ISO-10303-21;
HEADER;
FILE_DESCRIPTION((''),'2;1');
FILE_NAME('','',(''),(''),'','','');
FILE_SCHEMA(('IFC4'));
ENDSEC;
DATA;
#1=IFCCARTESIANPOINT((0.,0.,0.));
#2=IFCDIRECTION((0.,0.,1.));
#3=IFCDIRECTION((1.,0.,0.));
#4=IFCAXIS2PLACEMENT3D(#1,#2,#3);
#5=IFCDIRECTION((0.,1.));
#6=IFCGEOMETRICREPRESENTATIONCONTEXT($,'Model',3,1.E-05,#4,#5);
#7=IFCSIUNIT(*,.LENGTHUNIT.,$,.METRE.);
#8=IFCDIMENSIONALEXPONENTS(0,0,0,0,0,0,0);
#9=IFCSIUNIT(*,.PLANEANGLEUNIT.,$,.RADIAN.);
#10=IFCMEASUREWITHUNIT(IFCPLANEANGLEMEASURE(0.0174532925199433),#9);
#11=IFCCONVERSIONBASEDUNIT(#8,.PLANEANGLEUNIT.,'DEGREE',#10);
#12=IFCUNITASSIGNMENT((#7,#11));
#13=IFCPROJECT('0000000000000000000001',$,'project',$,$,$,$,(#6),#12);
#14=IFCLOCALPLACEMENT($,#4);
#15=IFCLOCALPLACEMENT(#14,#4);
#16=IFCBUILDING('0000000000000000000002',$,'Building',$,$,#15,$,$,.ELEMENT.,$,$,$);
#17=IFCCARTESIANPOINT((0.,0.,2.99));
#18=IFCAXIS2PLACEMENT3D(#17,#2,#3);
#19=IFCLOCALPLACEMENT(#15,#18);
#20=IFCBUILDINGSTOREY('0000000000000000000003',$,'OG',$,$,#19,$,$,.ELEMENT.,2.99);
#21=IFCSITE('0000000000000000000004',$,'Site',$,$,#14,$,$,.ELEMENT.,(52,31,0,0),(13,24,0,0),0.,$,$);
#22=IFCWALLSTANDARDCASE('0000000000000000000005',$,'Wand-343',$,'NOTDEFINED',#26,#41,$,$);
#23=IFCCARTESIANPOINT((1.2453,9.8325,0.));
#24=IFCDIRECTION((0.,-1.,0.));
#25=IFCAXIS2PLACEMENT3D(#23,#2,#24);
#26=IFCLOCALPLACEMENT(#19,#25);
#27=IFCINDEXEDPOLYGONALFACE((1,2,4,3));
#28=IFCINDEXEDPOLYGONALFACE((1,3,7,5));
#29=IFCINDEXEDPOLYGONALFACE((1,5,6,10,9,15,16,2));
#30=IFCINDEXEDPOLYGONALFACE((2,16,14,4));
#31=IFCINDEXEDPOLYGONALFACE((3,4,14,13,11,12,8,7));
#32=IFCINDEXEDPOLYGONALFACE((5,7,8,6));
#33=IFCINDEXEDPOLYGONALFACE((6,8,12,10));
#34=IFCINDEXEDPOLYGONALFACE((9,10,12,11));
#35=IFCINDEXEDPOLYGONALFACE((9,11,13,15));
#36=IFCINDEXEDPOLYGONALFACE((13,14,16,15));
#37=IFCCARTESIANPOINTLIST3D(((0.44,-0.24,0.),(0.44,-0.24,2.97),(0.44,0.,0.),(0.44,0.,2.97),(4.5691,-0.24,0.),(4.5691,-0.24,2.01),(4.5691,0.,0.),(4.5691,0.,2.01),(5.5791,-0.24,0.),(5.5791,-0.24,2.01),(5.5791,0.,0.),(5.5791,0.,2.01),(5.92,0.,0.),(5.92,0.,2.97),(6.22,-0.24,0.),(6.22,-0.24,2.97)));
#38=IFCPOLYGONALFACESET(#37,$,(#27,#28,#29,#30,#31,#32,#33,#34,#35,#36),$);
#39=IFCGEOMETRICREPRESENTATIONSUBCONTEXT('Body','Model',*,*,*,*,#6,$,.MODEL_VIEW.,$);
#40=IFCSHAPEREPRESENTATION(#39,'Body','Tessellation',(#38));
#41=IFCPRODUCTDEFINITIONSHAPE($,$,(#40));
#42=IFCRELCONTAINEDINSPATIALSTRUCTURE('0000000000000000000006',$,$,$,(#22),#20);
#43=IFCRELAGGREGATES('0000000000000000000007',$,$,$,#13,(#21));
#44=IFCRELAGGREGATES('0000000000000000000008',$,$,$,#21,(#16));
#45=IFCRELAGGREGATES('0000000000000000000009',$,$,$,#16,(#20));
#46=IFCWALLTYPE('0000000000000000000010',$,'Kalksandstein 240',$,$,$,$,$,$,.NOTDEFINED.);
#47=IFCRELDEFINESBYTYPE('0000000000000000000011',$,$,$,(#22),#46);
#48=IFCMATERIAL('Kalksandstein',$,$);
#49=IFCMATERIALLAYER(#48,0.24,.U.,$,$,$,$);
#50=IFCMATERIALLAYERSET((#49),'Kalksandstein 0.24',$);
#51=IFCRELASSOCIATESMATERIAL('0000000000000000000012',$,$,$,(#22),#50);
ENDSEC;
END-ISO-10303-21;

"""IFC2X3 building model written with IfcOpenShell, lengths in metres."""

from ifc_helpers import new_model, entity, si_unit, converted_unit, direction, frame, origin_with_axes, origin_2d_with_axis, place, context, subcontext, project, spatial, polyline, rectangle, outline, extrude, material, layer, layer_set, layer_usage, type_object, element, save


model = new_model("IFC2X3")

# Units and contexts
model_context = context("Model", 3, precision=1e-05, world=origin_with_axes(), true_north=direction((0.0, 1.0)))
body_context = subcontext(model_context, "Body", "Model", "MODEL_VIEW")
ifc_project = project(units=[si_unit("LENGTHUNIT", "METRE"), converted_unit("PLANEANGLEUNIT", "DEGREE", entity("IfcPlaneAngleMeasure", 0.0174532925199433), si_unit("PLANEANGLEUNIT", "RADIAN"), dimensions=[0, 0, 0, 0, 0, 0, 0])], contexts=[model_context])

# Site, building, storey
site_placement = place(None, origin_with_axes())
site = spatial("IfcSite", under=ifc_project, at=site_placement, Name="Site", CompositionType="ELEMENT", RefLatitude=(52, 31, 0, 0), RefLongitude=(13, 24, 0, 0), RefElevation=0.0)
building_placement = place(site_placement, origin_with_axes())
building = spatial("IfcBuilding", under=site, at=building_placement, Name="Building", CompositionType="ELEMENT")
storey_placement = place(building_placement, frame((0.0, 0.0, 2.99), z_axis=(0.0, 0.0, 1.0), x_axis=(1.0, 0.0, 0.0)))
storey = spatial("IfcBuildingStorey", under=building, at=storey_placement, Name="OG", CompositionType="ELEMENT", Elevation=2.99)

# Shared definitions
ifc_material = material(Name="Kalksandstein")

# Wall, opening
ifc_layer_1 = layer(ifc_material, 0.24, ventilated="UNKNOWN")
ifc_layer_set_1 = layer_set([ifc_layer_1], Name="Kalksandstein 0.24")
ifc_layer_usage_1 = layer_usage(ifc_layer_set_1, "AXIS2", "POSITIVE", -0.24)
wall_type_1 = type_object("IfcWallType", Name="Kalksandstein 240", PredefinedType="NOTDEFINED")
wall_1_placement = place(storey_placement, frame((1.2453, 9.8325, 0.0), z_axis=(0.0, 0.0, 1.0), x_axis=(0.0, -1.0, 0.0)))
wall_1 = element("IfcWallStandardCase", 1, at=wall_1_placement, inside=storey, type_object=wall_type_1, material=ifc_layer_usage_1, Name="Wand-343", ObjectType="NOTDEFINED", context=body_context, shape_type="SweptSolid", body=[
    extrude(outline(polyline([(0.44, -0.24), (6.22, -0.24), (5.92, 0.0), (0.44, 0.0), (0.44, -0.24)])), origin_with_axes(), (0.0, 0.0, 1.0), 2.97),
])
opening_1_placement = place(wall_1_placement, frame((5.0741, 0.0, 0.0), z_axis=(0.0, 0.0, 1.0), x_axis=(1.0, 0.0, 0.0)))
element("IfcOpeningElement", 2, at=opening_1_placement, cuts=wall_1, context=body_context, shape_type="SweptSolid", body=[
    extrude(rectangle(XDim=1.01, YDim=2.01, at=origin_2d_with_axis()), frame((0.0, -0.24, 1.005), z_axis=(0.0, -1.0, 0.0), x_axis=(-1.0, 0.0, 0.0)), (0.0, 0.0, -1.0), 0.72),
])

save(model, "model.ifc")
